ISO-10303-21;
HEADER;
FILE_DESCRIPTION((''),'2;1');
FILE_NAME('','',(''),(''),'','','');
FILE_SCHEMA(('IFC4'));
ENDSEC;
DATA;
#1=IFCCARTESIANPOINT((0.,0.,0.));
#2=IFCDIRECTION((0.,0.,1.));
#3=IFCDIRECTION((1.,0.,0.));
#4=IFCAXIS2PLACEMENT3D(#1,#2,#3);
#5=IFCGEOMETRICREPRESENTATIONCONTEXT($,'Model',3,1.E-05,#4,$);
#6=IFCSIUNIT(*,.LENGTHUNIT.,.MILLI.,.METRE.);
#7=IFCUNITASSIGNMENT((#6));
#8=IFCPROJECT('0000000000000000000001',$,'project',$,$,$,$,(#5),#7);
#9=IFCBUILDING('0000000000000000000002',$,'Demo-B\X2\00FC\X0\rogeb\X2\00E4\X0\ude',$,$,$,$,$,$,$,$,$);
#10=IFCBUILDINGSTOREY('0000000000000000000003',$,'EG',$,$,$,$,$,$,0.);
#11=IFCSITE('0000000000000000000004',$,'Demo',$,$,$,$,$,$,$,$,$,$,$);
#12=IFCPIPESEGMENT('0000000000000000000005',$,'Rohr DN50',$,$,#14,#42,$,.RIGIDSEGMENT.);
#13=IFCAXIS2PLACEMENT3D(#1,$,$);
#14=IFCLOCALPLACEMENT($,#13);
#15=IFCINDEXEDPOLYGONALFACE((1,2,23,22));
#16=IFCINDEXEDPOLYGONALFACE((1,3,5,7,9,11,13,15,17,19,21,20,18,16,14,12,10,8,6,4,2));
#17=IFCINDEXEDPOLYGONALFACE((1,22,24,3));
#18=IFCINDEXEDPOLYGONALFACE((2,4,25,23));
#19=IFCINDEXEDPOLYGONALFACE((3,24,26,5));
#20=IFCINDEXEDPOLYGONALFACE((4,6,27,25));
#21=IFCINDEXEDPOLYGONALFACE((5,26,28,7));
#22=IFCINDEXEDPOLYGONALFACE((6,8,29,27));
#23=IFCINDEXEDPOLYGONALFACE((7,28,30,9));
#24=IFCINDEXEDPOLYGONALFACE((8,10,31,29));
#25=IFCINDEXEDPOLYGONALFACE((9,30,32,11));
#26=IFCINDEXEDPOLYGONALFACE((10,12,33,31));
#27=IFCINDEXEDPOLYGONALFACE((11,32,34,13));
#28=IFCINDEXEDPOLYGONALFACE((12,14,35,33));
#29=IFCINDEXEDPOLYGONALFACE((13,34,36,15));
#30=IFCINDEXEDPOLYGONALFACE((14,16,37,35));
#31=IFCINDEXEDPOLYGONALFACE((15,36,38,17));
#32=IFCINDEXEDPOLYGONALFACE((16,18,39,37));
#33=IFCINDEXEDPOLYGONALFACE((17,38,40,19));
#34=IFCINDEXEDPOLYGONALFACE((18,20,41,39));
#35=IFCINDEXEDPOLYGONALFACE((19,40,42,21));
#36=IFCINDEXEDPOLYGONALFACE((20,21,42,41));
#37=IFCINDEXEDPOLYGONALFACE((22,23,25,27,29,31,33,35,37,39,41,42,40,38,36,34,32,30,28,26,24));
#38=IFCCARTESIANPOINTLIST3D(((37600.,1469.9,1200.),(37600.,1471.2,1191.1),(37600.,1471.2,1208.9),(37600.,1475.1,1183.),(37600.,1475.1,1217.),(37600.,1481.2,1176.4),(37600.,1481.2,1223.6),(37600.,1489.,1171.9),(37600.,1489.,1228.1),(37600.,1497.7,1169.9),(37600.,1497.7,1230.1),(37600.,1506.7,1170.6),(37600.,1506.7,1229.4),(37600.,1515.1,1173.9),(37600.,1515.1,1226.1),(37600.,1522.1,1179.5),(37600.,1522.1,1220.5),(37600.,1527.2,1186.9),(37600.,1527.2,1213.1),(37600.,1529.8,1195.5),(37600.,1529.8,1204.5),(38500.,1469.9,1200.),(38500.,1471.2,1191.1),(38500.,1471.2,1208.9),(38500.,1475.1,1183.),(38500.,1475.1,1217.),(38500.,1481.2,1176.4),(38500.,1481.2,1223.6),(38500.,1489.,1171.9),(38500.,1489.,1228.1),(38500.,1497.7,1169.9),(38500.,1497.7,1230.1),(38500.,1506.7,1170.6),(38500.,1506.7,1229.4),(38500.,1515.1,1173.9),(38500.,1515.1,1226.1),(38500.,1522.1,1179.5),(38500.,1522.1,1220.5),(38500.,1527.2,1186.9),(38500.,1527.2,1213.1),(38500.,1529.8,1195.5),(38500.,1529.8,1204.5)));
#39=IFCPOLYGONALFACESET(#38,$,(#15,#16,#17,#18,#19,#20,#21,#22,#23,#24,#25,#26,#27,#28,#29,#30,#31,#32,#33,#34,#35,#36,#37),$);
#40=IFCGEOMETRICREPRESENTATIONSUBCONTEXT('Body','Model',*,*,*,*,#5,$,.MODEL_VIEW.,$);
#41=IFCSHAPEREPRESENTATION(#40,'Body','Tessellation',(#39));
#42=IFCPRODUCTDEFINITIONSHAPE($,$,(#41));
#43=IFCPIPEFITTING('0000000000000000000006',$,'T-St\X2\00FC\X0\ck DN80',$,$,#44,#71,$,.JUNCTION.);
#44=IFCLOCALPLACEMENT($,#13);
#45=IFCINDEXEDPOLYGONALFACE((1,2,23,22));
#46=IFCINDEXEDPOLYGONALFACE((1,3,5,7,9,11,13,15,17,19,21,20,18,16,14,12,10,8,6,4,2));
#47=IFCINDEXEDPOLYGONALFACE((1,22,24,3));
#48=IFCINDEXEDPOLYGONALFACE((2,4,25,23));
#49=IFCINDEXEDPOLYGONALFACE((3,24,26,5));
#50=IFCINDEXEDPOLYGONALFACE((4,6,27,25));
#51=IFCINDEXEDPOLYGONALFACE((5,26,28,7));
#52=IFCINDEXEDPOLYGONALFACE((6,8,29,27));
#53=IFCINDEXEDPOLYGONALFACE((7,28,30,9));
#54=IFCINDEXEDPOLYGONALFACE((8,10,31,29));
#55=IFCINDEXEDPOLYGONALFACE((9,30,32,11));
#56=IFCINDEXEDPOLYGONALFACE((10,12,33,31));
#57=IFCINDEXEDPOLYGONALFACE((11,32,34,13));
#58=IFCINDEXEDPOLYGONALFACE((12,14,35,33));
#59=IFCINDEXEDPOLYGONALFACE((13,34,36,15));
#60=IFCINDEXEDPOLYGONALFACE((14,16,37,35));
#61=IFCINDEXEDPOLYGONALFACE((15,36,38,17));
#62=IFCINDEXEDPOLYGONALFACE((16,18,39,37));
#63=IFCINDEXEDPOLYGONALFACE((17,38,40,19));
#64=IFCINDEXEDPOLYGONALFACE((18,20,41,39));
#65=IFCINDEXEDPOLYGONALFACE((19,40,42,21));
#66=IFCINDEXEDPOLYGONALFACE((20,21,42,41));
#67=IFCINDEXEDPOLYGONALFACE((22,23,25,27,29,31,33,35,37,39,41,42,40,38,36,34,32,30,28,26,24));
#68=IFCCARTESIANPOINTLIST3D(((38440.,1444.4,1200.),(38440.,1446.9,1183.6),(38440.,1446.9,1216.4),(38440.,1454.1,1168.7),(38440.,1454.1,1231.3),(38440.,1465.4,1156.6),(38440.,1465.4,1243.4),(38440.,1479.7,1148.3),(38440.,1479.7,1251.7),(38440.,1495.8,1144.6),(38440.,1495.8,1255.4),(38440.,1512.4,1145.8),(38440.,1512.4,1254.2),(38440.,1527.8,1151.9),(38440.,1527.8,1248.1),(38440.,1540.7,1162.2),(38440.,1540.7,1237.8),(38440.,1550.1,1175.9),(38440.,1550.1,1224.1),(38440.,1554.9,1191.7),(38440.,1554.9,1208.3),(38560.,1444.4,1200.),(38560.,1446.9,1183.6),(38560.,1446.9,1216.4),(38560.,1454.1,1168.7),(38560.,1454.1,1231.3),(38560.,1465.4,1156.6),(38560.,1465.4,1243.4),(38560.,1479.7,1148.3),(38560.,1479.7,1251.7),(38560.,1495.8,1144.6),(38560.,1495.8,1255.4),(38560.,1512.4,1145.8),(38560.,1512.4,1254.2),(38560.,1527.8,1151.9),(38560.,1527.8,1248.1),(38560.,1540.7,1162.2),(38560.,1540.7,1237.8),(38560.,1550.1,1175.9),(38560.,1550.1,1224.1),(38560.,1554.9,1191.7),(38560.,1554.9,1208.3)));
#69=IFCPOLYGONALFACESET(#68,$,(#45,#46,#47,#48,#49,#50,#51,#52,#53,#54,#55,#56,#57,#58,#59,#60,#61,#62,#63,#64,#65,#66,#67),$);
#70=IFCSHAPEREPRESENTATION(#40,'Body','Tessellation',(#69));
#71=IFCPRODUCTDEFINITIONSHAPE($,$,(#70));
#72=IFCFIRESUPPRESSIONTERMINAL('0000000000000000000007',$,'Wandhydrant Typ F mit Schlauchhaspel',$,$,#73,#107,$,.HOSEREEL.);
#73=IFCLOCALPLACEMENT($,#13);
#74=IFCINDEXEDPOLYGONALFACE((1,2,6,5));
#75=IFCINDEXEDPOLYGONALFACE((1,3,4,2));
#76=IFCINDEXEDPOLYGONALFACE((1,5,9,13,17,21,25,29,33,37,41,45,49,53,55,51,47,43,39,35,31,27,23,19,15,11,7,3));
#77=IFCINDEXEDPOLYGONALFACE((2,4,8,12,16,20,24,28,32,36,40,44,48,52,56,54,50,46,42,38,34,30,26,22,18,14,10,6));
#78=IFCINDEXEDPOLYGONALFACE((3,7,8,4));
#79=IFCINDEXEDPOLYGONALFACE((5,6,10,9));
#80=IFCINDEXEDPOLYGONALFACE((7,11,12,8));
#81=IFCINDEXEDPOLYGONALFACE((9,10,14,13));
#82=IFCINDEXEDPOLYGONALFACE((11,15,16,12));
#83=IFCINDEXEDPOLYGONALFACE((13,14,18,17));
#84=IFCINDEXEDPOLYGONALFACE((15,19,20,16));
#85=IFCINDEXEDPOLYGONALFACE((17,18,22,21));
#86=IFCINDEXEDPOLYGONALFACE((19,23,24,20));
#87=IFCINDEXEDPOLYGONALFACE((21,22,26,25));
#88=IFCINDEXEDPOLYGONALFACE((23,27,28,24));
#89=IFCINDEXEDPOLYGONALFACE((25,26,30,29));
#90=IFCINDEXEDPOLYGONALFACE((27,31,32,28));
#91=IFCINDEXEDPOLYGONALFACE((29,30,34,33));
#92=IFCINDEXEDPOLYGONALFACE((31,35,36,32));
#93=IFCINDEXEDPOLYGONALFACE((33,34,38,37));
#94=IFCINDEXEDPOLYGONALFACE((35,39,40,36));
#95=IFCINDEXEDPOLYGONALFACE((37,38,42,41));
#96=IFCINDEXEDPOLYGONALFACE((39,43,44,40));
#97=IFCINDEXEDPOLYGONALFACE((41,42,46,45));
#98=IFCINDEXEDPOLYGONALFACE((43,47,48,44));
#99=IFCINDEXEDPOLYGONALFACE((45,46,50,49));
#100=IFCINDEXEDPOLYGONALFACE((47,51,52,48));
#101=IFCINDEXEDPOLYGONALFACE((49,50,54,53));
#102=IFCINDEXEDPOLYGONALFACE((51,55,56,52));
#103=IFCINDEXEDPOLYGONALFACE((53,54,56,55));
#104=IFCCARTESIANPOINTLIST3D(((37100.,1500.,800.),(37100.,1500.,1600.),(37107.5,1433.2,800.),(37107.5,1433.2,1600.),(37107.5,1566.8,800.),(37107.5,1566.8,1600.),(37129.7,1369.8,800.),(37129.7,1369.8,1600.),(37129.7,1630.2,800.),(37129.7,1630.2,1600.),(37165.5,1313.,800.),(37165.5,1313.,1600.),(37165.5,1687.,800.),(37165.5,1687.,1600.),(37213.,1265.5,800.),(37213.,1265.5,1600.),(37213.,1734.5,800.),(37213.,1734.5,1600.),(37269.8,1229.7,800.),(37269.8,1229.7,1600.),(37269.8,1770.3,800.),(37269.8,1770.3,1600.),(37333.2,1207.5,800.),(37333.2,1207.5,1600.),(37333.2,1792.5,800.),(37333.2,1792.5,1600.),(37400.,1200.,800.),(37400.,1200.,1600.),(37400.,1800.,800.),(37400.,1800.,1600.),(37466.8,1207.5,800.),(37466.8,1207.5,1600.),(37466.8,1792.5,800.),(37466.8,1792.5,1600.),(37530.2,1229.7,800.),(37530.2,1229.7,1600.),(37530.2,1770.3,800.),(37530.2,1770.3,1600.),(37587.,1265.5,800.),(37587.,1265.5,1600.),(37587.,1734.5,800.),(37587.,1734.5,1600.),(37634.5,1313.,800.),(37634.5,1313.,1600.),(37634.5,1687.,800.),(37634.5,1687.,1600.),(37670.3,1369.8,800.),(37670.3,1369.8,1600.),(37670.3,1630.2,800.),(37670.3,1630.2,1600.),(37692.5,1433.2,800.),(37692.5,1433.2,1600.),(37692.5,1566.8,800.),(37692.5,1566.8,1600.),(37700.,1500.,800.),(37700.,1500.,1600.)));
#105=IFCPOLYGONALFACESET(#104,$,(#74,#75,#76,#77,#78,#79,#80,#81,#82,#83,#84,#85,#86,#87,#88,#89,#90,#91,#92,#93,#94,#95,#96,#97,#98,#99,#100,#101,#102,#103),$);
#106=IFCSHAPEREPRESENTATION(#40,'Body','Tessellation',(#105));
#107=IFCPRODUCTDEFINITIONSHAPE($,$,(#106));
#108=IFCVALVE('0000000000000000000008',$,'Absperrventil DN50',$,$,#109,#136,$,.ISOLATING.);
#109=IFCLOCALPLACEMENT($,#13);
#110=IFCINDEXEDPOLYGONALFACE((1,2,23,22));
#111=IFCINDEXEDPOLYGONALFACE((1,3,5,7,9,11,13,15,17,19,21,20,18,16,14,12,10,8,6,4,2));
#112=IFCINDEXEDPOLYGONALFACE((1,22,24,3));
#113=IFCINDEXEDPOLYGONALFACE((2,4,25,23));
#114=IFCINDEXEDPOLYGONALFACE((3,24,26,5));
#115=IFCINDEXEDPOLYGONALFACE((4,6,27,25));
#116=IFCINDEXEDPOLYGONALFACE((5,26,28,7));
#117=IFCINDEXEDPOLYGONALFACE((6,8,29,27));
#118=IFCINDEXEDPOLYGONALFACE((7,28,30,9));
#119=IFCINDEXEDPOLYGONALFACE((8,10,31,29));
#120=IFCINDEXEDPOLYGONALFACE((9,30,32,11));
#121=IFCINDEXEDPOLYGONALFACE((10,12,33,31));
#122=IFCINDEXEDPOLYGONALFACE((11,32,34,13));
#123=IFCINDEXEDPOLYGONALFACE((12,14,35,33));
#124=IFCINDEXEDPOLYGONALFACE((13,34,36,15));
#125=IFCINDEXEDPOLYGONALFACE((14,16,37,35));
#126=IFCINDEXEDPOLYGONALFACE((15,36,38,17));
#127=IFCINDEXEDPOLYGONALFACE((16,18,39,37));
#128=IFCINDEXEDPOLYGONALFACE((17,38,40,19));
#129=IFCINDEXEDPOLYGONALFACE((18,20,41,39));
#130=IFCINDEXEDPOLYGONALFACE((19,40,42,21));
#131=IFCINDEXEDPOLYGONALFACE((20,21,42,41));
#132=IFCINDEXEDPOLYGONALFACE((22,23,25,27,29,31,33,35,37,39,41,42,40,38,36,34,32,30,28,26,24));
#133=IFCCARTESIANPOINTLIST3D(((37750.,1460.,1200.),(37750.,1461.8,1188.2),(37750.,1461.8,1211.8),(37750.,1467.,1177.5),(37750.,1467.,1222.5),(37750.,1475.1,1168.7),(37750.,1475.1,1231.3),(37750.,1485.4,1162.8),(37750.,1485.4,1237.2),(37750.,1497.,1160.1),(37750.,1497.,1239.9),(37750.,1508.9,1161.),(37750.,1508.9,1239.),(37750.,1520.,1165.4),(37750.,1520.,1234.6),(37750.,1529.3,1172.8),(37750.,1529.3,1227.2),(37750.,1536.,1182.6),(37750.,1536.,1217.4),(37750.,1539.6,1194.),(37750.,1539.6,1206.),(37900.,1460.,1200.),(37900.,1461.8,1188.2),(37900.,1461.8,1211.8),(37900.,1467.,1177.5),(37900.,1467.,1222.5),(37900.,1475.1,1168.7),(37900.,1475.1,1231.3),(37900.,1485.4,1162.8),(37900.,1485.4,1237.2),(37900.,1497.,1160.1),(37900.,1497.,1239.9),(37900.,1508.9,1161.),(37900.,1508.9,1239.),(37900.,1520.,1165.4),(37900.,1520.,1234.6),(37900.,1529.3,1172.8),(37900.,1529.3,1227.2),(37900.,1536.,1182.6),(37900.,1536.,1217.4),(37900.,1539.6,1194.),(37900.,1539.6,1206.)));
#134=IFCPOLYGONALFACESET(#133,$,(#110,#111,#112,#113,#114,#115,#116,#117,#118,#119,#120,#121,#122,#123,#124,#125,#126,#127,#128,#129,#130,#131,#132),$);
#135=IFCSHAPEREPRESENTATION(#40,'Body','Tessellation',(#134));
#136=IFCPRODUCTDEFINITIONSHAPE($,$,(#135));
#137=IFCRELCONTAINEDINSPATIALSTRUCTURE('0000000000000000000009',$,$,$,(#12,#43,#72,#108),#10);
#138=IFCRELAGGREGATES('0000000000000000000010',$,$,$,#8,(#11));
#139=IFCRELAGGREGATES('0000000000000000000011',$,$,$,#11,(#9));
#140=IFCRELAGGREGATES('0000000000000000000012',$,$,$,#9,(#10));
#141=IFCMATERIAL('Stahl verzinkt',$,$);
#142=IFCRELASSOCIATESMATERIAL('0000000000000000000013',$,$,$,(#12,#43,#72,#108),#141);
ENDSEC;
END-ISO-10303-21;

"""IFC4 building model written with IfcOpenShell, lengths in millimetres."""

from ifc_helpers import new_model, si_unit, frame, origin_with_axes, place, context, subcontext, project, spatial, circle, extrude, material, element, save


model = new_model("IFC4")

# Units and contexts
model_context = context("Model", 3, precision=1e-05, world=origin_with_axes())
body_context = subcontext(model_context, "Body", "Model", "MODEL_VIEW")
ifc_project = project(units=[si_unit("LENGTHUNIT", "METRE", prefix="MILLI")], contexts=[model_context])

# Site, building, storey
site = spatial("IfcSite", under=ifc_project, Name="Demo")
building = spatial("IfcBuilding", under=site, Name="Demo-Bürogebäude")
storey = spatial("IfcBuildingStorey", under=building, Name="EG", Elevation=0.0)

# Pipe segment
ifc_material_1 = material(Name="Stahl verzinkt")
pipe_segment_1_placement = place(None, frame((38500.0, 1500.0, 1200.0), z_axis=(-1.0, 0.0, 0.0), x_axis=(0.0, -1.0, 0.0)))
element("IfcPipeSegment", 1, at=pipe_segment_1_placement, inside=storey, material=ifc_material_1, Name="Rohr DN50", PredefinedType="RIGIDSEGMENT", context=body_context, shape_type="SweptSolid", body=[
    extrude(circle(Radius=30.1), origin_with_axes(), (0.0, 0.0, 1.0), 900.0),
])

# Pipe fitting
pipe_fitting_1_placement = place(None, frame((38560.0, 1500.0, 1200.0), z_axis=(-1.0, 0.0, 0.0), x_axis=(0.0, -1.0, 0.0)))
element("IfcPipeFitting", 2, at=pipe_fitting_1_placement, inside=storey, material=ifc_material_1, Name="T-Stück DN80", PredefinedType="JUNCTION", context=body_context, shape_type="SweptSolid", body=[
    extrude(circle(Radius=55.6), origin_with_axes(), (0.0, 0.0, 1.0), 120.0),
])

# Fire suppression terminal
fire_suppression_terminal_1_placement = place(None, frame((37400.0, 1500.0, 800.0), z_axis=(0.0, 0.0, 1.0), x_axis=(1.0, 0.0, 0.0)))
element("IfcFireSuppressionTerminal", 3, at=fire_suppression_terminal_1_placement, inside=storey, material=ifc_material_1, Name="Wandhydrant Typ F mit Schlauchhaspel", PredefinedType="HOSEREEL", context=body_context, shape_type="SweptSolid", body=[
    extrude(circle(Radius=300.0), origin_with_axes(), (0.0, 0.0, 1.0), 800.0),
])

# Valve
valve_placement = place(None, frame((37900.0, 1500.0, 1200.0), z_axis=(-1.0, 0.0, 0.0), x_axis=(0.0, -1.0, 0.0)))
element("IfcValve", 4, at=valve_placement, inside=storey, material=ifc_material_1, Name="Absperrventil DN50", PredefinedType="ISOLATING", context=body_context, shape_type="SweptSolid", body=[
    extrude(circle(Radius=40.0), origin_with_axes(), (0.0, 0.0, 1.0), 150.0),
])

save(model, "model.ifc")
